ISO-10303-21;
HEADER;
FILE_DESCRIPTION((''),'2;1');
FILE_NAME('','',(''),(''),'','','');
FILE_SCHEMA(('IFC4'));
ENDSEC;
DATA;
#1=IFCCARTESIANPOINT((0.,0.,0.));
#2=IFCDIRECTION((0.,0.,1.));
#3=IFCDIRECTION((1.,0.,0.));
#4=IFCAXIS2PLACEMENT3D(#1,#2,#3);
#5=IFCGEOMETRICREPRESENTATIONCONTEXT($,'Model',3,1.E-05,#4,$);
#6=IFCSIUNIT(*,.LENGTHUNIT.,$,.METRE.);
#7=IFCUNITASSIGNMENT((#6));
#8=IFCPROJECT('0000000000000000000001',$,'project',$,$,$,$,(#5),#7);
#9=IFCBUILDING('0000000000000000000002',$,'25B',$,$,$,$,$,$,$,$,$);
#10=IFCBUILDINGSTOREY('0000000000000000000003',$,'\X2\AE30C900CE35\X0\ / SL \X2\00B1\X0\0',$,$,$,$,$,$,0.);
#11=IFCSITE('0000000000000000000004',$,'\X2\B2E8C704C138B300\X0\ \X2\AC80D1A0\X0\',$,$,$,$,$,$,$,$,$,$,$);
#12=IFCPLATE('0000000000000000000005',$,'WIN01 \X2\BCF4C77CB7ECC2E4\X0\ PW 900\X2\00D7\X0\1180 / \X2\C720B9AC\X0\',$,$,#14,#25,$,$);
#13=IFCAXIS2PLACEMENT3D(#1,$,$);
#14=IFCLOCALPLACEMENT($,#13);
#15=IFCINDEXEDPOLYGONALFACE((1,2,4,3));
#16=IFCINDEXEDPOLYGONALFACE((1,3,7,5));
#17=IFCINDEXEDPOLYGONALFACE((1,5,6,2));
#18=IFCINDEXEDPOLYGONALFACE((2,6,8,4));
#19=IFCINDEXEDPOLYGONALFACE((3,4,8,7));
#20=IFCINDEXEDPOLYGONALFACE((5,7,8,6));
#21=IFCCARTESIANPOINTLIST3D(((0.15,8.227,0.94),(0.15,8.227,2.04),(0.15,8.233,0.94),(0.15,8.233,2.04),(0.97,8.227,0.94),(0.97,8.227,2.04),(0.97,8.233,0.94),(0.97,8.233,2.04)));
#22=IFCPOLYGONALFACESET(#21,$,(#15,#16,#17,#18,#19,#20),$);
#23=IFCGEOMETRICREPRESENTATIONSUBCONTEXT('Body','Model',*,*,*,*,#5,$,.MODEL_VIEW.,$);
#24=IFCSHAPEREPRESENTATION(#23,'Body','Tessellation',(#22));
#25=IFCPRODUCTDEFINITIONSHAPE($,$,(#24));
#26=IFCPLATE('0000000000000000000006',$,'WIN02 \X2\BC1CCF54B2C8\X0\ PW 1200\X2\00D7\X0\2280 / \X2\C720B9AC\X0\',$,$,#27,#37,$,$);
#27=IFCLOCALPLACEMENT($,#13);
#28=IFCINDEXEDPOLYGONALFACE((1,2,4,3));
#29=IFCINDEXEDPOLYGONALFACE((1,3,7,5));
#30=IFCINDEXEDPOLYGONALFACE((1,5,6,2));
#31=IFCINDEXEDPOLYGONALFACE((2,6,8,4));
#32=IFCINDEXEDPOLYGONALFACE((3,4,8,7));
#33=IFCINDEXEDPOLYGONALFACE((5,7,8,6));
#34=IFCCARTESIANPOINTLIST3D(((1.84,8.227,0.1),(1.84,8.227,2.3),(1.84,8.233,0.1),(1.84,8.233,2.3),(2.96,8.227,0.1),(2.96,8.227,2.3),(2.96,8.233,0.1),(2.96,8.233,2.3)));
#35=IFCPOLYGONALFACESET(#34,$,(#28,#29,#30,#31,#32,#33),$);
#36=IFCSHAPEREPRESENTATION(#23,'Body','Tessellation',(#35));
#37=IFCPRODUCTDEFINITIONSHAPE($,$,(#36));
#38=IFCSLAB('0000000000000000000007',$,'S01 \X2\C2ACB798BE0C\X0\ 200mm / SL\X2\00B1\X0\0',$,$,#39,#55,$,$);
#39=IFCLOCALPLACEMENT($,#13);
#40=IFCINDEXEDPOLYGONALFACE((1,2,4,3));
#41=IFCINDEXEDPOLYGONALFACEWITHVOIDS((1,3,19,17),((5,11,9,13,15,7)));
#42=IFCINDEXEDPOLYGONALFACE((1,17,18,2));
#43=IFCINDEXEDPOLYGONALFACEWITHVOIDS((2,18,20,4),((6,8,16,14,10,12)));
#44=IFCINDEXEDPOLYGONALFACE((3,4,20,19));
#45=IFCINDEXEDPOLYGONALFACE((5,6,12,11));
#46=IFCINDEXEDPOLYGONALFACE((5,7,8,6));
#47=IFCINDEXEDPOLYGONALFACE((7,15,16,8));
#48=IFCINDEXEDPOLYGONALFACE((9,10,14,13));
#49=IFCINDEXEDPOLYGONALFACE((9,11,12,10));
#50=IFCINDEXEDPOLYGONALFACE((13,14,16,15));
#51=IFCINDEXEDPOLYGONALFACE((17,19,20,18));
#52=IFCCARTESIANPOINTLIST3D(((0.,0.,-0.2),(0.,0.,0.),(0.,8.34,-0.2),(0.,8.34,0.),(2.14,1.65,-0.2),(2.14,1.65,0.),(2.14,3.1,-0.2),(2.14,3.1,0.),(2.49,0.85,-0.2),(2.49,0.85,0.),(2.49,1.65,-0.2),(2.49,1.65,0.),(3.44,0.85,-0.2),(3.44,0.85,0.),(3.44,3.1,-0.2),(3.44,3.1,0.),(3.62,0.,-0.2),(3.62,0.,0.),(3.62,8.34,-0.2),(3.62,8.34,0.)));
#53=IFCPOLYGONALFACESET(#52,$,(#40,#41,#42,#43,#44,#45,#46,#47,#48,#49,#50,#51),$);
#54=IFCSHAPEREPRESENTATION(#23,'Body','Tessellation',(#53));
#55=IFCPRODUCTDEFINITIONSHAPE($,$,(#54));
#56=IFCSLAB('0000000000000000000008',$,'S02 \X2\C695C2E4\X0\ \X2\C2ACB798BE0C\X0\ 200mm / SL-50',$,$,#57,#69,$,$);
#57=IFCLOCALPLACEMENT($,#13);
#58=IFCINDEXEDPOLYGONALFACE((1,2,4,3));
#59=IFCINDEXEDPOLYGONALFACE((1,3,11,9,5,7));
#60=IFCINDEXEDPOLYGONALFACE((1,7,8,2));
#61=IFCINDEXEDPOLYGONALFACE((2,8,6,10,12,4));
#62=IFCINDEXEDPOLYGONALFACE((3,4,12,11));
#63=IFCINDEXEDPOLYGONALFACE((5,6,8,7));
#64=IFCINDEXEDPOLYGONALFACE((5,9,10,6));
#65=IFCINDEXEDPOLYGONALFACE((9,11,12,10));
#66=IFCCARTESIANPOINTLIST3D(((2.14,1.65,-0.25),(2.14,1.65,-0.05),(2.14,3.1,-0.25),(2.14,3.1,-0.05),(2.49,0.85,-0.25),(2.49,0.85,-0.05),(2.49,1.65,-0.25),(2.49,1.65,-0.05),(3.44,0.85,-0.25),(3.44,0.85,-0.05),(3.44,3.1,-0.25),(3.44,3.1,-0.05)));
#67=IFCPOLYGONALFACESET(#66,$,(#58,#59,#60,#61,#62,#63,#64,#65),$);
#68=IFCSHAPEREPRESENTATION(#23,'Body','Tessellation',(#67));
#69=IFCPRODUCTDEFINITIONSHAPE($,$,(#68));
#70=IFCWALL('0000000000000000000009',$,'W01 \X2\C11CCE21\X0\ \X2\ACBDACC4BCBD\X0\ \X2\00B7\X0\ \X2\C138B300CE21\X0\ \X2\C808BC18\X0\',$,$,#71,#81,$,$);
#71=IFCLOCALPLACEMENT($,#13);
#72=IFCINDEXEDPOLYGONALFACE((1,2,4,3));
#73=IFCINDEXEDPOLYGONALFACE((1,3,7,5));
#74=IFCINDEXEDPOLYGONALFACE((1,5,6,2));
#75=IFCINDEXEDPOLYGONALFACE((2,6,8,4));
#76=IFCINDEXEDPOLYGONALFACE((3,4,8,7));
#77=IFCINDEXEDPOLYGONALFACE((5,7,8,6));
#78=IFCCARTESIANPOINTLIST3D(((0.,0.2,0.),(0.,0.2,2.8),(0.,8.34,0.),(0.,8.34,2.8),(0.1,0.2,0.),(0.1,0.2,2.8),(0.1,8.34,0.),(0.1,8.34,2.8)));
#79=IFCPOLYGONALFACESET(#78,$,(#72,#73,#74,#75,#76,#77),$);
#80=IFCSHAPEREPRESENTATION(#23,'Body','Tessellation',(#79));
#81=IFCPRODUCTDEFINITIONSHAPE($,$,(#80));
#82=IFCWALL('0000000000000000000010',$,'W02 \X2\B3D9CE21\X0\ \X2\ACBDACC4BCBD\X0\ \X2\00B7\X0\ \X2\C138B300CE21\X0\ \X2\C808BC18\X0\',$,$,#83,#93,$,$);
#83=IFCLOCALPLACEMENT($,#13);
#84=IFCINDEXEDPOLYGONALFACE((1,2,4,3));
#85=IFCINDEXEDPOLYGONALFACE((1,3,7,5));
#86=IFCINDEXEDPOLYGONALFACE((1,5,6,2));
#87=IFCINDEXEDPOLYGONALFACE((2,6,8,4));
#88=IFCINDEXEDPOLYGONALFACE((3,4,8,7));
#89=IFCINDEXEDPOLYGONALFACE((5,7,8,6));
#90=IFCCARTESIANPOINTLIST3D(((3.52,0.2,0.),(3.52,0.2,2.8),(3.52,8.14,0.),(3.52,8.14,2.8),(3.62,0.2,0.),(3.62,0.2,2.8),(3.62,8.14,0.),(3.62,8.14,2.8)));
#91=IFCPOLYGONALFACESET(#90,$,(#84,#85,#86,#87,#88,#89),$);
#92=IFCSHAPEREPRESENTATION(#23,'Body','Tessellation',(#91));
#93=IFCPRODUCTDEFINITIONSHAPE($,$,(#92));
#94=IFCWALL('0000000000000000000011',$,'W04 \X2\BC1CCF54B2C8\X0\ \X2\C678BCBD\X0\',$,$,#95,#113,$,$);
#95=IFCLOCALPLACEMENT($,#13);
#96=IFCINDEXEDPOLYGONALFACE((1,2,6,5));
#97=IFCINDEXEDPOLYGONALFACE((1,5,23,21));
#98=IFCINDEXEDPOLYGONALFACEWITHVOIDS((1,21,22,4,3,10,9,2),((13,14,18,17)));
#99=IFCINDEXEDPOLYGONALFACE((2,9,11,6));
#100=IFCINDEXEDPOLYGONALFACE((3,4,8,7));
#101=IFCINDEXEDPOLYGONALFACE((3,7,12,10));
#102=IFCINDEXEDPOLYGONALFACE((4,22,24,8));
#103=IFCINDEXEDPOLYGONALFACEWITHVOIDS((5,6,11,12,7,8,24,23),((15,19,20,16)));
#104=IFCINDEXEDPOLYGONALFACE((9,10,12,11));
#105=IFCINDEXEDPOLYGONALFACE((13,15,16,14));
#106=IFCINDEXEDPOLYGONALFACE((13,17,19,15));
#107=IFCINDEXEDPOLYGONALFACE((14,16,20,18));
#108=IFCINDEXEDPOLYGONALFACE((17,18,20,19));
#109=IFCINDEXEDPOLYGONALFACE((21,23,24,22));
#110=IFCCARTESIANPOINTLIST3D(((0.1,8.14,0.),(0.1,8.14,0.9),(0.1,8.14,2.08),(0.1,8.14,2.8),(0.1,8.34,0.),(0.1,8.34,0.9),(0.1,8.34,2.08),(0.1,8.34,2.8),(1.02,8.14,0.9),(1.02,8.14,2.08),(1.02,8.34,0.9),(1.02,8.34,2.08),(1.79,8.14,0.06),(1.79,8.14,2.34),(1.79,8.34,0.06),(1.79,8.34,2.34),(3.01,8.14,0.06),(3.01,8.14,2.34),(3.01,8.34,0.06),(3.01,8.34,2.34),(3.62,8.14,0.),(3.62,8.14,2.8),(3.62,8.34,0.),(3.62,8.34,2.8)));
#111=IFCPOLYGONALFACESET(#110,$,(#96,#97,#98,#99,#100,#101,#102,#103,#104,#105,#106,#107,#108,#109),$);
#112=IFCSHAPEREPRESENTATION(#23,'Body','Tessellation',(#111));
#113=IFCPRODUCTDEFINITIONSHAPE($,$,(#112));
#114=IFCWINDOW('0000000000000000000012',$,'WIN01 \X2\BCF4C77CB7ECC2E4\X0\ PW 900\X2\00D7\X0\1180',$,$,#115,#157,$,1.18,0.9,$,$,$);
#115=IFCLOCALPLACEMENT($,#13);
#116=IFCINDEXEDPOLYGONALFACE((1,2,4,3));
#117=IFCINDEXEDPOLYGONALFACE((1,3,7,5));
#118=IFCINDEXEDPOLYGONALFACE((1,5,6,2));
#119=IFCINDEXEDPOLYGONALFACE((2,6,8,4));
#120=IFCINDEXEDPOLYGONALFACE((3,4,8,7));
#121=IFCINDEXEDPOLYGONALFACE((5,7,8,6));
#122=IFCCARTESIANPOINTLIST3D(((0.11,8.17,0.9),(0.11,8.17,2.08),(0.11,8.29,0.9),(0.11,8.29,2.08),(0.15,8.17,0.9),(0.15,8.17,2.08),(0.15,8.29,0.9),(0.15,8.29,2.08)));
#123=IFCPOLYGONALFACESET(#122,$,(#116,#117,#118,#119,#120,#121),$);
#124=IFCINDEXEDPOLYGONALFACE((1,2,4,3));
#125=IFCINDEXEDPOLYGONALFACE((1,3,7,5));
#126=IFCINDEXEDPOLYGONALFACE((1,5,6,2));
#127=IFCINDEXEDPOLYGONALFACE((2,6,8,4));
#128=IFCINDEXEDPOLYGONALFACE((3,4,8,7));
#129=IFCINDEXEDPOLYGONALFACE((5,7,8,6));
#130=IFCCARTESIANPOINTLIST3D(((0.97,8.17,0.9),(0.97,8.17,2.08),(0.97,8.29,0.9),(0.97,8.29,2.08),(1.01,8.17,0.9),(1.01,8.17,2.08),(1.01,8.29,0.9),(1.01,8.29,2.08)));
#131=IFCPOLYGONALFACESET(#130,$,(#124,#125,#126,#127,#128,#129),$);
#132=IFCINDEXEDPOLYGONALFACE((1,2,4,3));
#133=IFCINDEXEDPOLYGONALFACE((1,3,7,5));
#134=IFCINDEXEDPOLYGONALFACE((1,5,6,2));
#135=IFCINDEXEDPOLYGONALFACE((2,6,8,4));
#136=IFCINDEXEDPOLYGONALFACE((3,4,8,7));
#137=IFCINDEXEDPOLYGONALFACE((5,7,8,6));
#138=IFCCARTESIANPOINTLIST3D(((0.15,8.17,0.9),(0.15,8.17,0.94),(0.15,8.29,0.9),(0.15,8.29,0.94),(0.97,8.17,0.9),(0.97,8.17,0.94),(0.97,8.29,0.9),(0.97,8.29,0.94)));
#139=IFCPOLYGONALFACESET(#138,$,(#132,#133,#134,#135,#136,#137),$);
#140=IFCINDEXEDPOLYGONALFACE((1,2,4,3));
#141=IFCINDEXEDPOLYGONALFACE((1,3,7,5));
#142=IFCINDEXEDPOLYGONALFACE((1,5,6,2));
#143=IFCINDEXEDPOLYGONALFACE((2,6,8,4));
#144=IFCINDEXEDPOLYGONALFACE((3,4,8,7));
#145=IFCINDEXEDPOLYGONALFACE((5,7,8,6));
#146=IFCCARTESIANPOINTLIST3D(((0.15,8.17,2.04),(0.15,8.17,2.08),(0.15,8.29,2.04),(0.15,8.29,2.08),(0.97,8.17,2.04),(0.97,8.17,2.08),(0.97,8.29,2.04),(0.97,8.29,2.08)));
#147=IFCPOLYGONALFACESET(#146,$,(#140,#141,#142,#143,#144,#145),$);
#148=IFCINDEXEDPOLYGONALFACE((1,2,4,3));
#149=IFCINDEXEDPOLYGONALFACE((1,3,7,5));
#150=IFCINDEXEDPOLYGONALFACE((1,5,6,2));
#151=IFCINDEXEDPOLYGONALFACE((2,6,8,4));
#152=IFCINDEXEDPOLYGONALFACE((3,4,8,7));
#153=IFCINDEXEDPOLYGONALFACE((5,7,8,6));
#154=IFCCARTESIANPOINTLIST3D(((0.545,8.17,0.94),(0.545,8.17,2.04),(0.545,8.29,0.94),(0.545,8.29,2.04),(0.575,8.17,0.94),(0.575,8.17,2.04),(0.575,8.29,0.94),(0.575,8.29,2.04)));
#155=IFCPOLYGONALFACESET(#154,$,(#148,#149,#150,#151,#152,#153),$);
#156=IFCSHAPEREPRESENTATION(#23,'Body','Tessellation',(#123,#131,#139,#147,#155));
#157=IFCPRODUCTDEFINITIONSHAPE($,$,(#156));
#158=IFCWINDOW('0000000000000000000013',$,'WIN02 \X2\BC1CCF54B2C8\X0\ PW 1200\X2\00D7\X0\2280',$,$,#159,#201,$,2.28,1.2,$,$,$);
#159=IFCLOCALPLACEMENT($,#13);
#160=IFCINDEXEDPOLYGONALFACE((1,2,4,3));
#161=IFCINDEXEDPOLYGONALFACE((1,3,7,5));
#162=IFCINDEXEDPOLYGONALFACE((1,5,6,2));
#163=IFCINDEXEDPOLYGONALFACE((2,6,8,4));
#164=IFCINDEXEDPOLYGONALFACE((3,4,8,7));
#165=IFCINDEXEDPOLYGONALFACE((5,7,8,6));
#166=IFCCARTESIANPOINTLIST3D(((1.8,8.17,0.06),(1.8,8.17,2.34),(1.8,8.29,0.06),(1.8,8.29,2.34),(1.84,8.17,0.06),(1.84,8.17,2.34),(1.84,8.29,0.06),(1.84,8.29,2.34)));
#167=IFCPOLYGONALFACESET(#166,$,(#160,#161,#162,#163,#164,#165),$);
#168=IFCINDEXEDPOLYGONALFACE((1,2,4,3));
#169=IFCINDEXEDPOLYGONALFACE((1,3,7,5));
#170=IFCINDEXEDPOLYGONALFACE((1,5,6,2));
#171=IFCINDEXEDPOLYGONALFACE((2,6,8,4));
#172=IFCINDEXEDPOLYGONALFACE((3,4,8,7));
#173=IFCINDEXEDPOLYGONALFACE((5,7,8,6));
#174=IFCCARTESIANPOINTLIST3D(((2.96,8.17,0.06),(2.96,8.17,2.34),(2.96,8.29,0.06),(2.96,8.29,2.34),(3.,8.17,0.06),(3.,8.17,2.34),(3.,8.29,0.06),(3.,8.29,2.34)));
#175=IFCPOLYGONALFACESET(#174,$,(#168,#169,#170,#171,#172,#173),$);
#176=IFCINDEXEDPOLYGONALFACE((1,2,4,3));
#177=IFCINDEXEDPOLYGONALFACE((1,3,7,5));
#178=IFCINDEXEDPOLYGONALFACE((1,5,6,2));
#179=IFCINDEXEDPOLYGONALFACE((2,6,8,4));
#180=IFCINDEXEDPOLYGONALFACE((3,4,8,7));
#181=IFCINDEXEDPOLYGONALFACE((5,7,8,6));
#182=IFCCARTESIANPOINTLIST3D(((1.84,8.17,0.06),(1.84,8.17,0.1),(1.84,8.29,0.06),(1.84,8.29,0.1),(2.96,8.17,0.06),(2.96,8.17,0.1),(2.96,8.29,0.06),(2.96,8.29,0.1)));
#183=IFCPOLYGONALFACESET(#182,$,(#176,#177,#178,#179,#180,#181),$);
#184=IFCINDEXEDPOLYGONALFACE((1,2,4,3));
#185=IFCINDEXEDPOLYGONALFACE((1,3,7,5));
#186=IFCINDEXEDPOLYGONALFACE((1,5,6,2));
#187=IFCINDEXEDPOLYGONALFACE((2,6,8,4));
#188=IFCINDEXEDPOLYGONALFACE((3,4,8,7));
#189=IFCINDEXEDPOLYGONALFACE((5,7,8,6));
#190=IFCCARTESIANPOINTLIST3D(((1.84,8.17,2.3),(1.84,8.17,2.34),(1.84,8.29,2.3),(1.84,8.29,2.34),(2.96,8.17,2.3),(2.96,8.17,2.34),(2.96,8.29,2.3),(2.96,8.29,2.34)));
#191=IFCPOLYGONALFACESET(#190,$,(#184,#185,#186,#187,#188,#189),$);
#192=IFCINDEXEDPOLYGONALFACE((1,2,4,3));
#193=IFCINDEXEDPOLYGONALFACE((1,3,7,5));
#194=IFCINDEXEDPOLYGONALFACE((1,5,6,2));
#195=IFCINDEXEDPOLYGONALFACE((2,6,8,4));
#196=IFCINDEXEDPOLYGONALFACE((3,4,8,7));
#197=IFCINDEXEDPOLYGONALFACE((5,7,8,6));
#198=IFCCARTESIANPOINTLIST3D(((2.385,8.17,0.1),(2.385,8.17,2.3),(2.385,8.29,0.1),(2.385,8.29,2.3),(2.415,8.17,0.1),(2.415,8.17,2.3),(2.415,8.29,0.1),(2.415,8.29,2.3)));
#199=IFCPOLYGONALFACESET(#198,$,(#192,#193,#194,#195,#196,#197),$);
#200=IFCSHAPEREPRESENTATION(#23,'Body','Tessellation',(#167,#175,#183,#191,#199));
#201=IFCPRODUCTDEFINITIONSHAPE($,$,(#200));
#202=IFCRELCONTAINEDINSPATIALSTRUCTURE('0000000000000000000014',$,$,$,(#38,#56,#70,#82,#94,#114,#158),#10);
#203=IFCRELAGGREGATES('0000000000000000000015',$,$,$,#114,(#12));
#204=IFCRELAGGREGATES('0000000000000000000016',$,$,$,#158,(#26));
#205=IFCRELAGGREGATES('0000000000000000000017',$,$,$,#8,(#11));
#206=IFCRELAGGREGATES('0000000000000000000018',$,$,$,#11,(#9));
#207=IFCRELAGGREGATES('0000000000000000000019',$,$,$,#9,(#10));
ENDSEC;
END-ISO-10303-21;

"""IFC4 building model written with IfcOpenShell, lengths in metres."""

from ifc_helpers import new_model, si_unit, frame, origin, origin_with_axes, place, context, subcontext, project, spatial, polyline, indexed_curve, outline, extrude, element, fill, aggregate, save


model = new_model("IFC4")

# Units and contexts
model_context = context("Model", 3, precision=1e-05, world=origin_with_axes())
body_context = subcontext(model_context, "Body", "Model", "MODEL_VIEW")
ifc_project = project(units=[si_unit("LENGTHUNIT", "METRE")], contexts=[model_context])

# Plates
window_1_placement = place(None, origin_with_axes())
plate_1_placement = place(window_1_placement, origin_with_axes())
plate_1 = element("IfcPlate", 1, at=plate_1_placement, Name="WIN01 보일러실 PW 900×1180 / 유리", context=body_context, shape_type="SweptSolid", body=[
    extrude(outline(polyline([(0.97, 8.227), (0.97, 8.233), (0.15, 8.233), (0.15, 8.227), (0.97, 8.227)])), frame((0.0, 0.0, 0.94)), (0.0, 0.0, 1.0), 1.1),
])
window_2_placement = place(None, origin_with_axes())
plate_2_placement = place(window_2_placement, origin_with_axes())
plate_2 = element("IfcPlate", 2, at=plate_2_placement, Name="WIN02 발코니 PW 1200×2280 / 유리", context=body_context, shape_type="SweptSolid", body=[
    extrude(outline(polyline([(2.96, 8.227), (2.96, 8.233), (1.84, 8.233), (1.84, 8.227), (2.96, 8.227)])), frame((0.0, 0.0, 0.1)), (0.0, 0.0, 1.0), 2.2),
])

# Site, building, storey
site = spatial("IfcSite", under=ifc_project, Name="단위세대 검토")
building = spatial("IfcBuilding", under=site, Name="25B")
storey = spatial("IfcBuildingStorey", under=building, Name="기준층 / SL ±0", Elevation=0.0)

# Slabs
slab_1_placement = place(None, origin_with_axes())
element("IfcSlab", 3, at=slab_1_placement, inside=storey, Name="S01 슬래브 200mm / SL±0", context=body_context, shape_type="SweptSolid", body=[
    extrude(outline(polyline([(0.0, 0.0), (0.0, 8.34), (3.62, 8.34), (3.62, 0.0), (0.0, 0.0)]), holes=[polyline([(2.49, 1.65), (2.49, 0.85), (3.44, 0.85), (3.44, 3.1), (2.14, 3.1), (2.14, 1.65), (2.49, 1.65)])]), frame((0.0, 0.0, -0.2)), (0.0, 0.0, 1.0), 0.2),
])
slab_2_placement = place(None, origin_with_axes())
element("IfcSlab", 4, at=slab_2_placement, inside=storey, Name="S02 욕실 슬래브 200mm / SL-50", context=body_context, shape_type="SweptSolid", body=[
    extrude(outline(polyline([(2.14, 1.65), (2.49, 1.65), (2.49, 0.85), (3.44, 0.85), (3.44, 3.1), (2.14, 3.1), (2.14, 1.65)])), frame((0.0, 0.0, -0.25)), (0.0, 0.0, 1.0), 0.2),
])

# Walls
wall_1_placement = place(None, origin_with_axes())
element("IfcWall", 5, at=wall_1_placement, inside=storey, Name="W01 서측 경계벽 · 세대측 절반", context=body_context, shape_type="SweptSolid", body=[
    extrude(outline(indexed_curve([(0.0, 8.34), (0.1, 8.34), (0.1, 0.2), (0.0, 0.2)])), origin(), (0.0, 0.0, 1.0), 2.8),
])
wall_2_placement = place(None, origin_with_axes())
element("IfcWall", 6, at=wall_2_placement, inside=storey, Name="W02 동측 경계벽 · 세대측 절반", context=body_context, shape_type="SweptSolid", body=[
    extrude(outline(polyline([(3.62, 0.2), (3.62, 8.14), (3.52, 8.14), (3.52, 0.2), (3.62, 0.2)])), origin(), (0.0, 0.0, 1.0), 2.8),
])

# Wall, openings, windows
wall_3_placement = place(None, origin_with_axes())
wall_3 = element("IfcWall", 7, at=wall_3_placement, inside=storey, Name="W04 발코니 외벽", context=body_context, shape_type="SweptSolid", body=[
    extrude(outline(polyline([(3.62, 8.14), (3.62, 8.34), (0.1, 8.34), (0.1, 8.14), (3.62, 8.14)])), origin(), (0.0, 0.0, 1.0), 2.8),
])
opening_1_placement = place(wall_3_placement, origin_with_axes())
opening_1 = element("IfcOpeningElement", 8, at=opening_1_placement, cuts=wall_3, context=body_context, shape_type="SweptSolid", body=[
    extrude(outline(polyline([(1.02, 8.139), (1.02, 8.341), (0.1, 8.341), (0.1, 8.139), (1.02, 8.139)])), frame((0.0, 0.0, 0.9)), (0.0, 0.0, 1.0), 1.18),
])
opening_2_placement = place(wall_3_placement, origin_with_axes())
opening_2 = element("IfcOpeningElement", 9, at=opening_2_placement, cuts=wall_3, context=body_context, shape_type="SweptSolid", body=[
    extrude(outline(polyline([(3.01, 8.139), (3.01, 8.341), (1.79, 8.341), (1.79, 8.139), (3.01, 8.139)])), frame((0.0, 0.0, 0.06)), (0.0, 0.0, 1.0), 2.28),
])
window_1 = element("IfcWindow", 10, at=window_1_placement, inside=storey, Name="WIN01 보일러실 PW 900×1180", OverallHeight=1.18, OverallWidth=0.9, context=body_context, shape_type="SweptSolid", body=[
    extrude(outline(polyline([(0.15, 8.17), (0.15, 8.29), (0.11, 8.29), (0.11, 8.17), (0.15, 8.17)])), frame((0.0, 0.0, 0.9)), (0.0, 0.0, 1.0), 1.18),
    extrude(outline(polyline([(1.01, 8.17), (1.01, 8.29), (0.97, 8.29), (0.97, 8.17), (1.01, 8.17)])), frame((0.0, 0.0, 0.9)), (0.0, 0.0, 1.0), 1.18),
    extrude(outline(polyline([(0.97, 8.17), (0.97, 8.29), (0.15, 8.29), (0.15, 8.17), (0.97, 8.17)])), frame((0.0, 0.0, 0.9)), (0.0, 0.0, 1.0), 0.04),
    extrude(outline(polyline([(0.97, 8.17), (0.97, 8.29), (0.15, 8.29), (0.15, 8.17), (0.97, 8.17)])), frame((0.0, 0.0, 2.04)), (0.0, 0.0, 1.0), 0.04),
    extrude(outline(polyline([(0.575, 8.17), (0.575, 8.29), (0.545, 8.29), (0.545, 8.17), (0.575, 8.17)])), frame((0.0, 0.0, 0.94)), (0.0, 0.0, 1.0), 1.1),
])
fill(opening_1, window_1)
window_2 = element("IfcWindow", 11, at=window_2_placement, inside=storey, Name="WIN02 발코니 PW 1200×2280", OverallHeight=2.28, OverallWidth=1.2, context=body_context, shape_type="SweptSolid", body=[
    extrude(outline(polyline([(1.84, 8.17), (1.84, 8.29), (1.8, 8.29), (1.8, 8.17), (1.84, 8.17)])), frame((0.0, 0.0, 0.06)), (0.0, 0.0, 1.0), 2.28),
    extrude(outline(polyline([(3.0, 8.17), (3.0, 8.29), (2.96, 8.29), (2.96, 8.17), (3.0, 8.17)])), frame((0.0, 0.0, 0.06)), (0.0, 0.0, 1.0), 2.28),
    extrude(outline(polyline([(2.96, 8.17), (2.96, 8.29), (1.84, 8.29), (1.84, 8.17), (2.96, 8.17)])), frame((0.0, 0.0, 0.06)), (0.0, 0.0, 1.0), 0.04),
    extrude(outline(polyline([(2.96, 8.17), (2.96, 8.29), (1.84, 8.29), (1.84, 8.17), (2.96, 8.17)])), frame((0.0, 0.0, 2.3)), (0.0, 0.0, 1.0), 0.04),
    extrude(outline(polyline([(2.415, 8.17), (2.415, 8.29), (2.385, 8.29), (2.385, 8.17), (2.415, 8.17)])), frame((0.0, 0.0, 0.1)), (0.0, 0.0, 1.0), 2.2),
])
fill(opening_2, window_2)
aggregate(window_1, [plate_1])
aggregate(window_2, [plate_2])

save(model, "model.ifc")
